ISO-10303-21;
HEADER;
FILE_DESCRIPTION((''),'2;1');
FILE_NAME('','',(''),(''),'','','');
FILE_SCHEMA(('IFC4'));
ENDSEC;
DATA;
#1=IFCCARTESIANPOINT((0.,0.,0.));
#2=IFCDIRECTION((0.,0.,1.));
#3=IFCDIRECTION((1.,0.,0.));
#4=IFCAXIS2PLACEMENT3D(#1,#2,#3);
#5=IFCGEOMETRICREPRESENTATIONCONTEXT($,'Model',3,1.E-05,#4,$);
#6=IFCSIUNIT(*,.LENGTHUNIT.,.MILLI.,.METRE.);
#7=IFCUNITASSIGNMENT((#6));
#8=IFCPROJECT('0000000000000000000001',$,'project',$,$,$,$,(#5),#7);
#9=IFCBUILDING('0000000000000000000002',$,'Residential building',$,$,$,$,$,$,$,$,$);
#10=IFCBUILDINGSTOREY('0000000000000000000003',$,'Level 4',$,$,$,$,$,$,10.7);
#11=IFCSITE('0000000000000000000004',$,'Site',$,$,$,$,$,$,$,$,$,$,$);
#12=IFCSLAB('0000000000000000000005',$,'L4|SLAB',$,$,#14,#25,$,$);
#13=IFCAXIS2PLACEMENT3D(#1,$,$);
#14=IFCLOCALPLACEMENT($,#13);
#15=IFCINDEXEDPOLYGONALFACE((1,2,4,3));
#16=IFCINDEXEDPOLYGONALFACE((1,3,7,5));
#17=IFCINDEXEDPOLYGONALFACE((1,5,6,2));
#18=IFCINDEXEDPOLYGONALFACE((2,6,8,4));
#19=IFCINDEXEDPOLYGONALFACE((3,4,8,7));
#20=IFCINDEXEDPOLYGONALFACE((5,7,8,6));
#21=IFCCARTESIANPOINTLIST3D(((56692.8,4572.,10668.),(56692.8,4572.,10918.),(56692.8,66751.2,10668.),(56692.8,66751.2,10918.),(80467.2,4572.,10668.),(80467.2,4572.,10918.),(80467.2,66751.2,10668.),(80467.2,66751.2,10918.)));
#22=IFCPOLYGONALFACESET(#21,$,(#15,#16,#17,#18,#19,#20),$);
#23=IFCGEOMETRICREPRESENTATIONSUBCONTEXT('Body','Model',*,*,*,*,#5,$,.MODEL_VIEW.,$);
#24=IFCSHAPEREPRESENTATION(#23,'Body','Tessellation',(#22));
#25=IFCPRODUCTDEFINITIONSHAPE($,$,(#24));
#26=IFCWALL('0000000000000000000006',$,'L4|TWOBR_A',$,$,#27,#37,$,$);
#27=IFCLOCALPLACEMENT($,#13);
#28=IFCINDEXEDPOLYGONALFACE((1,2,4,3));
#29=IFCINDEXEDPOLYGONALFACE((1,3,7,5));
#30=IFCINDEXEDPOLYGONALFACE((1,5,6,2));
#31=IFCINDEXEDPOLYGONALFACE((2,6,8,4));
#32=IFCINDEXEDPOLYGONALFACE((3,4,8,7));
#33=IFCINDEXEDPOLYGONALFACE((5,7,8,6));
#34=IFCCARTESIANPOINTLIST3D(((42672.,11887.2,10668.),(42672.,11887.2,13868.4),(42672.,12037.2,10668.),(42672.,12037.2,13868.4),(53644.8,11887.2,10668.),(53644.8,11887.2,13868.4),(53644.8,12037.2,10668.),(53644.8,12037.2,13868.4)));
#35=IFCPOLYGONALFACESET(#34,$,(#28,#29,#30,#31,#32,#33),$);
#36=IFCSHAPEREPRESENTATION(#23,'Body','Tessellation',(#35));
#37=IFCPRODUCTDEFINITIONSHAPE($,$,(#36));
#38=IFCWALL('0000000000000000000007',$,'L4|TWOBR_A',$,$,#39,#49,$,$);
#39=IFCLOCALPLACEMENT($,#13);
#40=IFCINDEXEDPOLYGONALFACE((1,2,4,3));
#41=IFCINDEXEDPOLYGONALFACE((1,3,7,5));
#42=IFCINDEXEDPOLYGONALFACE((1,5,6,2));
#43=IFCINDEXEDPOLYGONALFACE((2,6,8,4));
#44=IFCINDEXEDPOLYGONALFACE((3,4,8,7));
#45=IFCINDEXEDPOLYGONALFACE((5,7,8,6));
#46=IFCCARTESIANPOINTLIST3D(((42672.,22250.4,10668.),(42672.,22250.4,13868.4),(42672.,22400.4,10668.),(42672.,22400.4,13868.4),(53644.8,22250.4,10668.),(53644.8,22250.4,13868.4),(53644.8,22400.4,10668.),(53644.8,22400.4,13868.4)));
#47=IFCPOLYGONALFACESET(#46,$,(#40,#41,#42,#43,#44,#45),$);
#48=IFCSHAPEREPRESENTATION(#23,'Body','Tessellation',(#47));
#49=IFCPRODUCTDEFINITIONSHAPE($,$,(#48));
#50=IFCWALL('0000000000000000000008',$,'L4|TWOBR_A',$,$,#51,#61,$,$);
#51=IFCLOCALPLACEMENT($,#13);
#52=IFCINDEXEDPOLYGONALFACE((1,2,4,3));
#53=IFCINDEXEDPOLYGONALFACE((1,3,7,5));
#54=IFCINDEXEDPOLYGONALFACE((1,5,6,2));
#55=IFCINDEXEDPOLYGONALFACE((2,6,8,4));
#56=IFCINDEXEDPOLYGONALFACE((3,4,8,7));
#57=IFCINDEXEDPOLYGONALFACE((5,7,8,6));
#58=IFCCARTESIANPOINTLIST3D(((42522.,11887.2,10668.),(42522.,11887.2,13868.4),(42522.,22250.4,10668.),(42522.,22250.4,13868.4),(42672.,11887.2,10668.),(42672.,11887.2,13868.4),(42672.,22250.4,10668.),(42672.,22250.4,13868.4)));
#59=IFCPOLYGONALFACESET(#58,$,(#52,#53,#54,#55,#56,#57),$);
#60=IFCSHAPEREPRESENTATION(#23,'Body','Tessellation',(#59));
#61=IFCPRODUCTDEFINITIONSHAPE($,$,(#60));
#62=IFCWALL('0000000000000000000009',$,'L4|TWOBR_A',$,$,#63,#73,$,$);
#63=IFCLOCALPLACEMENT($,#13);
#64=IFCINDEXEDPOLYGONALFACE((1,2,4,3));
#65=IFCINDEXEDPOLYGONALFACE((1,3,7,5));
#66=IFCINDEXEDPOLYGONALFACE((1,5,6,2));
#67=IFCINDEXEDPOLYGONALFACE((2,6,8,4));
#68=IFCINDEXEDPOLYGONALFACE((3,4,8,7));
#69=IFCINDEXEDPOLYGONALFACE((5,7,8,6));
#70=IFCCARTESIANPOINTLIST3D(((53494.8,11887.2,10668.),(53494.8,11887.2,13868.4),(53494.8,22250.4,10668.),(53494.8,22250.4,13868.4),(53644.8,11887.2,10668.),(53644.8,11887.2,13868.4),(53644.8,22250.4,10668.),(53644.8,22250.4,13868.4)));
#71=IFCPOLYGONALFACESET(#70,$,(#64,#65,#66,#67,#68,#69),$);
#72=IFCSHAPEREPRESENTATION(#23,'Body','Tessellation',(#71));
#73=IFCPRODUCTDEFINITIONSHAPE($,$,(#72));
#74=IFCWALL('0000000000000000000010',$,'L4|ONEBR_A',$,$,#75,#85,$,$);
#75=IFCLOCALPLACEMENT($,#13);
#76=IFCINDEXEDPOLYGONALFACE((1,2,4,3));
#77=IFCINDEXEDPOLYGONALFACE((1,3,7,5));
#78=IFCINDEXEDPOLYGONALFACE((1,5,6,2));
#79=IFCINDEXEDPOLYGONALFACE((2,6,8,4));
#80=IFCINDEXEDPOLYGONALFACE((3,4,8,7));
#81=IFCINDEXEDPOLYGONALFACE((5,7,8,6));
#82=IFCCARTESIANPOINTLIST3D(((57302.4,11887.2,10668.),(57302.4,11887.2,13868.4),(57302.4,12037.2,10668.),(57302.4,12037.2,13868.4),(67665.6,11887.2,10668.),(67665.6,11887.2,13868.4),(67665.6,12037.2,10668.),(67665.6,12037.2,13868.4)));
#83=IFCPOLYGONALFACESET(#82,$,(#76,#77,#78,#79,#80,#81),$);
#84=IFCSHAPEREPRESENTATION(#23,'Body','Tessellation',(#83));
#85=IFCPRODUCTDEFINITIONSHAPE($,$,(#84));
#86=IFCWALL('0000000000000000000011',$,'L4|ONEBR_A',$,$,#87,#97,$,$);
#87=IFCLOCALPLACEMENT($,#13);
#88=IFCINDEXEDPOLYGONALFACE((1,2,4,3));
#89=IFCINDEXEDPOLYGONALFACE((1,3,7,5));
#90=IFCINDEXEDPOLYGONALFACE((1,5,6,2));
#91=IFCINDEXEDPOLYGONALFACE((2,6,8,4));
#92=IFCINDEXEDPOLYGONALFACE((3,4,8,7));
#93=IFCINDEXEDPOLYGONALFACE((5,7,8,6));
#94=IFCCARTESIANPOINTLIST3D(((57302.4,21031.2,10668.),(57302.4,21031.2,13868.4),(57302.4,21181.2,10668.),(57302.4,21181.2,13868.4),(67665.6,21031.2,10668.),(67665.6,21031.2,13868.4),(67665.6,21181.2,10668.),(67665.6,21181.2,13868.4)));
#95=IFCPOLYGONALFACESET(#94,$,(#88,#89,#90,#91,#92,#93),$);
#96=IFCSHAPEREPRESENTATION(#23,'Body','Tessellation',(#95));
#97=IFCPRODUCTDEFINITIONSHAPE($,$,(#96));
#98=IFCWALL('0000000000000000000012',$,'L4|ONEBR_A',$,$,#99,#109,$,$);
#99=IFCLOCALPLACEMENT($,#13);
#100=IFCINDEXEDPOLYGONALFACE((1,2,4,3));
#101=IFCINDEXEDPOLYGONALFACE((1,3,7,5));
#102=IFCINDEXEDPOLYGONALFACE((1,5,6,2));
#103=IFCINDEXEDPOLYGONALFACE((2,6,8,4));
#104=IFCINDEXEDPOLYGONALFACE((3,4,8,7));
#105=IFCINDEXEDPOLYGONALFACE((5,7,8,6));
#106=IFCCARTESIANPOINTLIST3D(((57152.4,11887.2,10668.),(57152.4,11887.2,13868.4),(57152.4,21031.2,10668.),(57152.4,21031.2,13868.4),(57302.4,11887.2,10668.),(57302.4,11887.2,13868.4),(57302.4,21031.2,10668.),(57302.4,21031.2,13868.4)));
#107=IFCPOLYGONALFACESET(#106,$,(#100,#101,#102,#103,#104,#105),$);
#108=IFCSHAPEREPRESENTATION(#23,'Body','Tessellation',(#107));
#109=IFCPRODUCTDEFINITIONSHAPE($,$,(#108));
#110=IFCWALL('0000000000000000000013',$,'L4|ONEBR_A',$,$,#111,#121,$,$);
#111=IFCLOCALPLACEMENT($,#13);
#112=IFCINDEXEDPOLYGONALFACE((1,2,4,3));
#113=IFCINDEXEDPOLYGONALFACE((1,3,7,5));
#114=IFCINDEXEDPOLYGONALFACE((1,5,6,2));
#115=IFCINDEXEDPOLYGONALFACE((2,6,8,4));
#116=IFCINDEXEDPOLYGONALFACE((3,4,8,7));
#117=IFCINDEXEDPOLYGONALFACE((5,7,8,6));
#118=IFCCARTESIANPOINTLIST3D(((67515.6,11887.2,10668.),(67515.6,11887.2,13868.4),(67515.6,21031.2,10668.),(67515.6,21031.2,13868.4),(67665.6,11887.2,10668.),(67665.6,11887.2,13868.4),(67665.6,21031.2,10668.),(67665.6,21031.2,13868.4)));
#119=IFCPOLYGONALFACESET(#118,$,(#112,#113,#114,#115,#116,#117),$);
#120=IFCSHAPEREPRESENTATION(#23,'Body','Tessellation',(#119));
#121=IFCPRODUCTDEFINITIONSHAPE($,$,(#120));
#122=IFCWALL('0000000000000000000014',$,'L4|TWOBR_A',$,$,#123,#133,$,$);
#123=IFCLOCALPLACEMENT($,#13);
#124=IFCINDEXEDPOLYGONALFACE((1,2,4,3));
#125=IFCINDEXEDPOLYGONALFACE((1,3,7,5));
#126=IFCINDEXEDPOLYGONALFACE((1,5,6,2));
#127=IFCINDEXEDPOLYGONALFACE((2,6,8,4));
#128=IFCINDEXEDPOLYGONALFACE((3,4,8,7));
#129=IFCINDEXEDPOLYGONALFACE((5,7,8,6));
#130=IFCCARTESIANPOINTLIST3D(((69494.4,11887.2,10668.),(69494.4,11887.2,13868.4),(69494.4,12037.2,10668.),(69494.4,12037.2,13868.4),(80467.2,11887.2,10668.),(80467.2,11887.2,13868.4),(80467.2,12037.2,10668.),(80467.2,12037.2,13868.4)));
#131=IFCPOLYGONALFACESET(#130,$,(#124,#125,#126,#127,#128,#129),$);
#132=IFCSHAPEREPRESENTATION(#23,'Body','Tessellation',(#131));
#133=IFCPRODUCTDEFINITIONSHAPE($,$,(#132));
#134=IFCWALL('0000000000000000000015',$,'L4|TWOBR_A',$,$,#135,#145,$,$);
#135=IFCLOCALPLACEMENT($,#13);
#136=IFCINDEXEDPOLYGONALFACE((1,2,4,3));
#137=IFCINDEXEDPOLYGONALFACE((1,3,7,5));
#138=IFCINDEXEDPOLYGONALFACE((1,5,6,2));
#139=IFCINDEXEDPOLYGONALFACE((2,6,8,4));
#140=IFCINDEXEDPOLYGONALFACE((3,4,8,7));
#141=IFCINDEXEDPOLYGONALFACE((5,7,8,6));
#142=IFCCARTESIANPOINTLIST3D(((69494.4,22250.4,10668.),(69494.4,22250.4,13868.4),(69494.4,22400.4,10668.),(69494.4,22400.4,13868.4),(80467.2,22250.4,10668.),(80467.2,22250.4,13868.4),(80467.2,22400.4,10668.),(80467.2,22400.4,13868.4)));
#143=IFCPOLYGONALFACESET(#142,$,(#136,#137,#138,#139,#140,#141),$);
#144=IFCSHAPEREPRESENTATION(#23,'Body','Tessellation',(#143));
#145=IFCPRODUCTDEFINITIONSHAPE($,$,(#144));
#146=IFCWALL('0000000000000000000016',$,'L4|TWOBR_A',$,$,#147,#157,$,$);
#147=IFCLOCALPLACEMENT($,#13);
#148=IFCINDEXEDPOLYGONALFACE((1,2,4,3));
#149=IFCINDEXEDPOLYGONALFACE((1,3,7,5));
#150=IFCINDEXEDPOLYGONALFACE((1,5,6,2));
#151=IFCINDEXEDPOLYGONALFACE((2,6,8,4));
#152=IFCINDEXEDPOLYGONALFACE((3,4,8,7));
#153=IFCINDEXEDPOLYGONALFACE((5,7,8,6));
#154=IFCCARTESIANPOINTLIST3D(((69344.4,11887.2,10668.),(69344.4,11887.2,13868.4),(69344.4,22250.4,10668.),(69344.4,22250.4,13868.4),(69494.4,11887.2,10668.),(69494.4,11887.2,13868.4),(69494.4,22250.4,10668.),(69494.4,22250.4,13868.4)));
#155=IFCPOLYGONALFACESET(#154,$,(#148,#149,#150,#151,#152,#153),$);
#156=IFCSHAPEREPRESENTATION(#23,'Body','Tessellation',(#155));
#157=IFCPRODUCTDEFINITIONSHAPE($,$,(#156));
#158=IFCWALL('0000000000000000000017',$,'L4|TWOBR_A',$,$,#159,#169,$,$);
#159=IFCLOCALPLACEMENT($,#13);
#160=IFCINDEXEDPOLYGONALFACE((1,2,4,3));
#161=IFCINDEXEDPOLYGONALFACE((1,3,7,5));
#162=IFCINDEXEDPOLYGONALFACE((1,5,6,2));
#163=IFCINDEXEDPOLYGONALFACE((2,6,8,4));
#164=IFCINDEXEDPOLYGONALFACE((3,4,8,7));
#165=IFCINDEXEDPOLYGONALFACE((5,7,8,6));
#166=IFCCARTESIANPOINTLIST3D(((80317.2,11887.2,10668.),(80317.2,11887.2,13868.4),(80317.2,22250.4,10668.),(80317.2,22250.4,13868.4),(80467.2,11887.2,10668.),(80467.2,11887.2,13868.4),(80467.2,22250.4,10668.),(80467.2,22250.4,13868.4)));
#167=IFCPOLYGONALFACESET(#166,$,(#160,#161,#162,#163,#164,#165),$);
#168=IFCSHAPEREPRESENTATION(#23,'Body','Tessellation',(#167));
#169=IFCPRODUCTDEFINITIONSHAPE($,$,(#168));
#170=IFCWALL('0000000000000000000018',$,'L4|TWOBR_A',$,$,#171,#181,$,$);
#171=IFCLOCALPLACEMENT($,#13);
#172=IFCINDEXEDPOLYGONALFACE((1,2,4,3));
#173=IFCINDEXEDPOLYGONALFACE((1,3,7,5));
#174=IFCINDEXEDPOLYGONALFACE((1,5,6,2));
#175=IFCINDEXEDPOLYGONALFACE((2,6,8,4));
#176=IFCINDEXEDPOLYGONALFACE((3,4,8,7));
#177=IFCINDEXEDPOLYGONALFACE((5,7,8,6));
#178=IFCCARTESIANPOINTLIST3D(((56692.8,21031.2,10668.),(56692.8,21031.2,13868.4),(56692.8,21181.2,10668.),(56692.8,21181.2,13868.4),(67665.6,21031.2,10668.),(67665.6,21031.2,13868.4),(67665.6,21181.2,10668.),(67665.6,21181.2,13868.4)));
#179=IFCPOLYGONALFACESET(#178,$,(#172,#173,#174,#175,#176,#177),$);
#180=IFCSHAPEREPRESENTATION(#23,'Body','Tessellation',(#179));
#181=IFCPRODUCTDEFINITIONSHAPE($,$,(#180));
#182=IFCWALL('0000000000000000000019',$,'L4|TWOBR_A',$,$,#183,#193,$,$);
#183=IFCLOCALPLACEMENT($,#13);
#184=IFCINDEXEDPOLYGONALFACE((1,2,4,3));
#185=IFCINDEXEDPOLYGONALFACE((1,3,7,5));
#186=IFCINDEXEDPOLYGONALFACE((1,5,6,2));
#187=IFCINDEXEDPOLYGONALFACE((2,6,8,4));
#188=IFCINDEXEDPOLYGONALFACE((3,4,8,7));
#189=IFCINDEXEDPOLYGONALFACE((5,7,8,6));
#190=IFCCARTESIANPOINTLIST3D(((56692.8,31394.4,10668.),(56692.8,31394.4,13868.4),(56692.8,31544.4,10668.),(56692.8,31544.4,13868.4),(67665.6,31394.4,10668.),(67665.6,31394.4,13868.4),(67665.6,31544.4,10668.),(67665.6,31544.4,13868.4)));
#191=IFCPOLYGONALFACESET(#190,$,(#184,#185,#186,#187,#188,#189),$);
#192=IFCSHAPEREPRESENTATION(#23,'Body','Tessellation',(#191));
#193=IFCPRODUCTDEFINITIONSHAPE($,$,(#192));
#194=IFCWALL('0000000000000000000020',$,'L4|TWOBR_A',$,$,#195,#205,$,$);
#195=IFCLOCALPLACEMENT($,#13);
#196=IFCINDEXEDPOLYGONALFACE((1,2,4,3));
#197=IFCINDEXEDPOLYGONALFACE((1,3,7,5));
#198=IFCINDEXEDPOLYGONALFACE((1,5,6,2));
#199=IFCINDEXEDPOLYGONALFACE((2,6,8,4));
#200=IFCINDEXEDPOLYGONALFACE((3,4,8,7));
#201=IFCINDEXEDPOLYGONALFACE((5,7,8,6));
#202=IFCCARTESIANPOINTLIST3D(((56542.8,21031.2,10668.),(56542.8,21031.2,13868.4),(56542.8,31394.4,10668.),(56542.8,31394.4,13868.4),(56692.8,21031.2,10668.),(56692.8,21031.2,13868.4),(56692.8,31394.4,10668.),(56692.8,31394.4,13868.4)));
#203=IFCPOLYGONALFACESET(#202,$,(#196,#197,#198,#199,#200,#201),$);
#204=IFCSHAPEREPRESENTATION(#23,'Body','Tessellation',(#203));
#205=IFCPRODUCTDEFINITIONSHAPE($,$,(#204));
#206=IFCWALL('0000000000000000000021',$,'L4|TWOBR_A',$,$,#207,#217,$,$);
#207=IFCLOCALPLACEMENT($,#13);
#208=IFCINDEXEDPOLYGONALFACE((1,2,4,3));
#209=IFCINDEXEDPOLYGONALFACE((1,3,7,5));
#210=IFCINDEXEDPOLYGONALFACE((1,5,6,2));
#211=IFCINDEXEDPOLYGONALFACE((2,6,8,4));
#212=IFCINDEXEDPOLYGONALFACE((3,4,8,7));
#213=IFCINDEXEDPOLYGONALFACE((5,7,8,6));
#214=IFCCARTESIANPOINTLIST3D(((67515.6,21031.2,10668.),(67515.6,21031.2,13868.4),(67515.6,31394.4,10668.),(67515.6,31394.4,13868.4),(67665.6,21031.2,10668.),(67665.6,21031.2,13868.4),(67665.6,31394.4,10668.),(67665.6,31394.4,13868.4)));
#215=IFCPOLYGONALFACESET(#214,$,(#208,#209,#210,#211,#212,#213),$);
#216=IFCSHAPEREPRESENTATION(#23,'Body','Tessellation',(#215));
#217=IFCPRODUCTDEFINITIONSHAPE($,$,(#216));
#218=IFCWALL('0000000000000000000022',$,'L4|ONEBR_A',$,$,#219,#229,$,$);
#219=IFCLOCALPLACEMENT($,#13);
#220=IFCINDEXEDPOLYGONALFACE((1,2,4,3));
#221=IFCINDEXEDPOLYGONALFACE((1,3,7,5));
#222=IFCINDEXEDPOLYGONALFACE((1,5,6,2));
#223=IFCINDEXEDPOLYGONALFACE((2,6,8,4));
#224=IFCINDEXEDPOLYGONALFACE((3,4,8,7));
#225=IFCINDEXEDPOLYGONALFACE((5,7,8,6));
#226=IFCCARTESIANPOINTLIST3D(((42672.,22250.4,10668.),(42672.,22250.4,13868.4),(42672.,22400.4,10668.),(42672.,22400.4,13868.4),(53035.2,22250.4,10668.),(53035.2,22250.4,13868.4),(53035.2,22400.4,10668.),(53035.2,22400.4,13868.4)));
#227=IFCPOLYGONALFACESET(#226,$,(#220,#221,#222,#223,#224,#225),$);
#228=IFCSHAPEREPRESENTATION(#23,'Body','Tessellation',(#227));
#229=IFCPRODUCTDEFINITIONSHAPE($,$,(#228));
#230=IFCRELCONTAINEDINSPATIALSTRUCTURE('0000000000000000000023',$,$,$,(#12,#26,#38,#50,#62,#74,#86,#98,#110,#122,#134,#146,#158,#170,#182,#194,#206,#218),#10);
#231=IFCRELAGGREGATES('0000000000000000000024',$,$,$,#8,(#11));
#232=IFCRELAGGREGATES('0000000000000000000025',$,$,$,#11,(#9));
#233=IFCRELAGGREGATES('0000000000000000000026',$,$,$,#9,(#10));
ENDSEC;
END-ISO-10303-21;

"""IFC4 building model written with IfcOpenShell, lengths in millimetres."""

from ifc_helpers import new_model, si_unit, frame, origin_with_axes, place, context, subcontext, project, spatial, indexed_curve, outline, extrude, element, save


model = new_model("IFC4")

# Units and contexts
model_context = context("Model", 3, precision=1e-05, world=origin_with_axes())
body_context = subcontext(model_context, "Body", "Model", "MODEL_VIEW")
ifc_project = project(units=[si_unit("LENGTHUNIT", "METRE", prefix="MILLI")], contexts=[model_context])

# Site, building, storey
site = spatial("IfcSite", under=ifc_project, Name="Site")
building = spatial("IfcBuilding", under=site, Name="Residential building")
storey = spatial("IfcBuildingStorey", under=building, Name="Level 4", Elevation=10.7)

# Slab
slab_placement = place(None, frame((56692.8, 4572.0, 10668.0), z_axis=(0.0, 0.0, 1.0), x_axis=(1.0, 0.0, 0.0)))
element("IfcSlab", 1, at=slab_placement, inside=storey, Name="L4|SLAB", context=body_context, shape_type="SweptSolid", body=[
    extrude(outline(indexed_curve([(0.0, 0.0), (23774.4, 0.0), (23774.4, 62179.2), (0.0, 62179.2), (0.0, 0.0)])), None, (0.0, 0.0, 1.0), 250.0),
])

# Walls
for number, where, z_axis, x_axis, name in (
    (2, (42672.0, 11887.2, 10668.0), (0.0, 0.0, 1.0), (1.0, 0.0, 0.0), "L4|TWOBR_A"),
    (3, (42672.0, 22250.4, 10668.0), (0.0, 0.0, 1.0), (1.0, 0.0, 0.0), "L4|TWOBR_A"),
):
    element("IfcWall", number, at=place(None, frame(where, z_axis=z_axis, x_axis=x_axis)), inside=storey, Name=name, context=body_context, shape_type="SweptSolid", body=[
        extrude(outline(indexed_curve([(0.0, 0.0), (0.0, 150.0), (10972.8, 150.0), (10972.8, 0.0), (0.0, 0.0)], self_intersect=False)), origin_with_axes(), (0.0, 0.0, 1.0), 3200.4),
    ])
for number, where, z_axis, x_axis, name in (
    (4, (42672.0, 11887.2, 10668.0), (0.0, 0.0, 1.0), (0.0, 1.0, 0.0), "L4|TWOBR_A"),
    (5, (53644.8, 11887.2, 10668.0), (0.0, 0.0, 1.0), (0.0, 1.0, 0.0), "L4|TWOBR_A"),
    (6, (57302.4, 11887.2, 10668.0), (0.0, 0.0, 1.0), (1.0, 0.0, 0.0), "L4|ONEBR_A"),
    (7, (57302.4, 21031.2, 10668.0), (0.0, 0.0, 1.0), (1.0, 0.0, 0.0), "L4|ONEBR_A"),
):
    element("IfcWall", number, at=place(None, frame(where, z_axis=z_axis, x_axis=x_axis)), inside=storey, Name=name, context=body_context, shape_type="SweptSolid", body=[
        extrude(outline(indexed_curve([(0.0, 0.0), (0.0, 150.0), (10363.2, 150.0), (10363.2, 0.0), (0.0, 0.0)], self_intersect=False)), origin_with_axes(), (0.0, 0.0, 1.0), 3200.4),
    ])
for number, where, z_axis, x_axis, name in (
    (8, (57302.4, 11887.2, 10668.0), (0.0, 0.0, 1.0), (0.0, 1.0, 0.0), "L4|ONEBR_A"),
    (9, (67665.6, 11887.2, 10668.0), (0.0, 0.0, 1.0), (0.0, 1.0, 0.0), "L4|ONEBR_A"),
):
    element("IfcWall", number, at=place(None, frame(where, z_axis=z_axis, x_axis=x_axis)), inside=storey, Name=name, context=body_context, shape_type="SweptSolid", body=[
        extrude(outline(indexed_curve([(0.0, 0.0), (0.0, 150.0), (9144.0, 150.0), (9144.0, 0.0), (0.0, 0.0)], self_intersect=False)), origin_with_axes(), (0.0, 0.0, 1.0), 3200.4),
    ])
for number, where, z_axis, x_axis, name in (
    (10, (69494.4, 11887.2, 10668.0), (0.0, 0.0, 1.0), (1.0, 0.0, 0.0), "L4|TWOBR_A"),
    (11, (69494.4, 22250.4, 10668.0), (0.0, 0.0, 1.0), (1.0, 0.0, 0.0), "L4|TWOBR_A"),
):
    element("IfcWall", number, at=place(None, frame(where, z_axis=z_axis, x_axis=x_axis)), inside=storey, Name=name, context=body_context, shape_type="SweptSolid", body=[
        extrude(outline(indexed_curve([(0.0, 0.0), (0.0, 150.0), (10972.8, 150.0), (10972.8, 0.0), (0.0, 0.0)], self_intersect=False)), origin_with_axes(), (0.0, 0.0, 1.0), 3200.4),
    ])
for number, where, z_axis, x_axis, name in (
    (12, (69494.4, 11887.2, 10668.0), (0.0, 0.0, 1.0), (0.0, 1.0, 0.0), "L4|TWOBR_A"),
    (13, (80467.2, 11887.2, 10668.0), (0.0, 0.0, 1.0), (0.0, 1.0, 0.0), "L4|TWOBR_A"),
):
    element("IfcWall", number, at=place(None, frame(where, z_axis=z_axis, x_axis=x_axis)), inside=storey, Name=name, context=body_context, shape_type="SweptSolid", body=[
        extrude(outline(indexed_curve([(0.0, 0.0), (0.0, 150.0), (10363.2, 150.0), (10363.2, 0.0), (0.0, 0.0)], self_intersect=False)), origin_with_axes(), (0.0, 0.0, 1.0), 3200.4),
    ])
for number, where, z_axis, x_axis, name in (
    (14, (56692.8, 21031.2, 10668.0), (0.0, 0.0, 1.0), (1.0, 0.0, 0.0), "L4|TWOBR_A"),
    (15, (56692.8, 31394.4, 10668.0), (0.0, 0.0, 1.0), (1.0, 0.0, 0.0), "L4|TWOBR_A"),
):
    element("IfcWall", number, at=place(None, frame(where, z_axis=z_axis, x_axis=x_axis)), inside=storey, Name=name, context=body_context, shape_type="SweptSolid", body=[
        extrude(outline(indexed_curve([(0.0, 0.0), (0.0, 150.0), (10972.8, 150.0), (10972.8, 0.0), (0.0, 0.0)], self_intersect=False)), origin_with_axes(), (0.0, 0.0, 1.0), 3200.4),
    ])
for number, where, z_axis, x_axis, name in (
    (16, (56692.8, 21031.2, 10668.0), (0.0, 0.0, 1.0), (0.0, 1.0, 0.0), "L4|TWOBR_A"),
    (17, (67665.6, 21031.2, 10668.0), (0.0, 0.0, 1.0), (0.0, 1.0, 0.0), "L4|TWOBR_A"),
    (18, (42672.0, 22250.4, 10668.0), (0.0, 0.0, 1.0), (1.0, 0.0, 0.0), "L4|ONEBR_A"),
):
    element("IfcWall", number, at=place(None, frame(where, z_axis=z_axis, x_axis=x_axis)), inside=storey, Name=name, context=body_context, shape_type="SweptSolid", body=[
        extrude(outline(indexed_curve([(0.0, 0.0), (0.0, 150.0), (10363.2, 150.0), (10363.2, 0.0), (0.0, 0.0)], self_intersect=False)), origin_with_axes(), (0.0, 0.0, 1.0), 3200.4),
    ])

save(model, "model.ifc")
